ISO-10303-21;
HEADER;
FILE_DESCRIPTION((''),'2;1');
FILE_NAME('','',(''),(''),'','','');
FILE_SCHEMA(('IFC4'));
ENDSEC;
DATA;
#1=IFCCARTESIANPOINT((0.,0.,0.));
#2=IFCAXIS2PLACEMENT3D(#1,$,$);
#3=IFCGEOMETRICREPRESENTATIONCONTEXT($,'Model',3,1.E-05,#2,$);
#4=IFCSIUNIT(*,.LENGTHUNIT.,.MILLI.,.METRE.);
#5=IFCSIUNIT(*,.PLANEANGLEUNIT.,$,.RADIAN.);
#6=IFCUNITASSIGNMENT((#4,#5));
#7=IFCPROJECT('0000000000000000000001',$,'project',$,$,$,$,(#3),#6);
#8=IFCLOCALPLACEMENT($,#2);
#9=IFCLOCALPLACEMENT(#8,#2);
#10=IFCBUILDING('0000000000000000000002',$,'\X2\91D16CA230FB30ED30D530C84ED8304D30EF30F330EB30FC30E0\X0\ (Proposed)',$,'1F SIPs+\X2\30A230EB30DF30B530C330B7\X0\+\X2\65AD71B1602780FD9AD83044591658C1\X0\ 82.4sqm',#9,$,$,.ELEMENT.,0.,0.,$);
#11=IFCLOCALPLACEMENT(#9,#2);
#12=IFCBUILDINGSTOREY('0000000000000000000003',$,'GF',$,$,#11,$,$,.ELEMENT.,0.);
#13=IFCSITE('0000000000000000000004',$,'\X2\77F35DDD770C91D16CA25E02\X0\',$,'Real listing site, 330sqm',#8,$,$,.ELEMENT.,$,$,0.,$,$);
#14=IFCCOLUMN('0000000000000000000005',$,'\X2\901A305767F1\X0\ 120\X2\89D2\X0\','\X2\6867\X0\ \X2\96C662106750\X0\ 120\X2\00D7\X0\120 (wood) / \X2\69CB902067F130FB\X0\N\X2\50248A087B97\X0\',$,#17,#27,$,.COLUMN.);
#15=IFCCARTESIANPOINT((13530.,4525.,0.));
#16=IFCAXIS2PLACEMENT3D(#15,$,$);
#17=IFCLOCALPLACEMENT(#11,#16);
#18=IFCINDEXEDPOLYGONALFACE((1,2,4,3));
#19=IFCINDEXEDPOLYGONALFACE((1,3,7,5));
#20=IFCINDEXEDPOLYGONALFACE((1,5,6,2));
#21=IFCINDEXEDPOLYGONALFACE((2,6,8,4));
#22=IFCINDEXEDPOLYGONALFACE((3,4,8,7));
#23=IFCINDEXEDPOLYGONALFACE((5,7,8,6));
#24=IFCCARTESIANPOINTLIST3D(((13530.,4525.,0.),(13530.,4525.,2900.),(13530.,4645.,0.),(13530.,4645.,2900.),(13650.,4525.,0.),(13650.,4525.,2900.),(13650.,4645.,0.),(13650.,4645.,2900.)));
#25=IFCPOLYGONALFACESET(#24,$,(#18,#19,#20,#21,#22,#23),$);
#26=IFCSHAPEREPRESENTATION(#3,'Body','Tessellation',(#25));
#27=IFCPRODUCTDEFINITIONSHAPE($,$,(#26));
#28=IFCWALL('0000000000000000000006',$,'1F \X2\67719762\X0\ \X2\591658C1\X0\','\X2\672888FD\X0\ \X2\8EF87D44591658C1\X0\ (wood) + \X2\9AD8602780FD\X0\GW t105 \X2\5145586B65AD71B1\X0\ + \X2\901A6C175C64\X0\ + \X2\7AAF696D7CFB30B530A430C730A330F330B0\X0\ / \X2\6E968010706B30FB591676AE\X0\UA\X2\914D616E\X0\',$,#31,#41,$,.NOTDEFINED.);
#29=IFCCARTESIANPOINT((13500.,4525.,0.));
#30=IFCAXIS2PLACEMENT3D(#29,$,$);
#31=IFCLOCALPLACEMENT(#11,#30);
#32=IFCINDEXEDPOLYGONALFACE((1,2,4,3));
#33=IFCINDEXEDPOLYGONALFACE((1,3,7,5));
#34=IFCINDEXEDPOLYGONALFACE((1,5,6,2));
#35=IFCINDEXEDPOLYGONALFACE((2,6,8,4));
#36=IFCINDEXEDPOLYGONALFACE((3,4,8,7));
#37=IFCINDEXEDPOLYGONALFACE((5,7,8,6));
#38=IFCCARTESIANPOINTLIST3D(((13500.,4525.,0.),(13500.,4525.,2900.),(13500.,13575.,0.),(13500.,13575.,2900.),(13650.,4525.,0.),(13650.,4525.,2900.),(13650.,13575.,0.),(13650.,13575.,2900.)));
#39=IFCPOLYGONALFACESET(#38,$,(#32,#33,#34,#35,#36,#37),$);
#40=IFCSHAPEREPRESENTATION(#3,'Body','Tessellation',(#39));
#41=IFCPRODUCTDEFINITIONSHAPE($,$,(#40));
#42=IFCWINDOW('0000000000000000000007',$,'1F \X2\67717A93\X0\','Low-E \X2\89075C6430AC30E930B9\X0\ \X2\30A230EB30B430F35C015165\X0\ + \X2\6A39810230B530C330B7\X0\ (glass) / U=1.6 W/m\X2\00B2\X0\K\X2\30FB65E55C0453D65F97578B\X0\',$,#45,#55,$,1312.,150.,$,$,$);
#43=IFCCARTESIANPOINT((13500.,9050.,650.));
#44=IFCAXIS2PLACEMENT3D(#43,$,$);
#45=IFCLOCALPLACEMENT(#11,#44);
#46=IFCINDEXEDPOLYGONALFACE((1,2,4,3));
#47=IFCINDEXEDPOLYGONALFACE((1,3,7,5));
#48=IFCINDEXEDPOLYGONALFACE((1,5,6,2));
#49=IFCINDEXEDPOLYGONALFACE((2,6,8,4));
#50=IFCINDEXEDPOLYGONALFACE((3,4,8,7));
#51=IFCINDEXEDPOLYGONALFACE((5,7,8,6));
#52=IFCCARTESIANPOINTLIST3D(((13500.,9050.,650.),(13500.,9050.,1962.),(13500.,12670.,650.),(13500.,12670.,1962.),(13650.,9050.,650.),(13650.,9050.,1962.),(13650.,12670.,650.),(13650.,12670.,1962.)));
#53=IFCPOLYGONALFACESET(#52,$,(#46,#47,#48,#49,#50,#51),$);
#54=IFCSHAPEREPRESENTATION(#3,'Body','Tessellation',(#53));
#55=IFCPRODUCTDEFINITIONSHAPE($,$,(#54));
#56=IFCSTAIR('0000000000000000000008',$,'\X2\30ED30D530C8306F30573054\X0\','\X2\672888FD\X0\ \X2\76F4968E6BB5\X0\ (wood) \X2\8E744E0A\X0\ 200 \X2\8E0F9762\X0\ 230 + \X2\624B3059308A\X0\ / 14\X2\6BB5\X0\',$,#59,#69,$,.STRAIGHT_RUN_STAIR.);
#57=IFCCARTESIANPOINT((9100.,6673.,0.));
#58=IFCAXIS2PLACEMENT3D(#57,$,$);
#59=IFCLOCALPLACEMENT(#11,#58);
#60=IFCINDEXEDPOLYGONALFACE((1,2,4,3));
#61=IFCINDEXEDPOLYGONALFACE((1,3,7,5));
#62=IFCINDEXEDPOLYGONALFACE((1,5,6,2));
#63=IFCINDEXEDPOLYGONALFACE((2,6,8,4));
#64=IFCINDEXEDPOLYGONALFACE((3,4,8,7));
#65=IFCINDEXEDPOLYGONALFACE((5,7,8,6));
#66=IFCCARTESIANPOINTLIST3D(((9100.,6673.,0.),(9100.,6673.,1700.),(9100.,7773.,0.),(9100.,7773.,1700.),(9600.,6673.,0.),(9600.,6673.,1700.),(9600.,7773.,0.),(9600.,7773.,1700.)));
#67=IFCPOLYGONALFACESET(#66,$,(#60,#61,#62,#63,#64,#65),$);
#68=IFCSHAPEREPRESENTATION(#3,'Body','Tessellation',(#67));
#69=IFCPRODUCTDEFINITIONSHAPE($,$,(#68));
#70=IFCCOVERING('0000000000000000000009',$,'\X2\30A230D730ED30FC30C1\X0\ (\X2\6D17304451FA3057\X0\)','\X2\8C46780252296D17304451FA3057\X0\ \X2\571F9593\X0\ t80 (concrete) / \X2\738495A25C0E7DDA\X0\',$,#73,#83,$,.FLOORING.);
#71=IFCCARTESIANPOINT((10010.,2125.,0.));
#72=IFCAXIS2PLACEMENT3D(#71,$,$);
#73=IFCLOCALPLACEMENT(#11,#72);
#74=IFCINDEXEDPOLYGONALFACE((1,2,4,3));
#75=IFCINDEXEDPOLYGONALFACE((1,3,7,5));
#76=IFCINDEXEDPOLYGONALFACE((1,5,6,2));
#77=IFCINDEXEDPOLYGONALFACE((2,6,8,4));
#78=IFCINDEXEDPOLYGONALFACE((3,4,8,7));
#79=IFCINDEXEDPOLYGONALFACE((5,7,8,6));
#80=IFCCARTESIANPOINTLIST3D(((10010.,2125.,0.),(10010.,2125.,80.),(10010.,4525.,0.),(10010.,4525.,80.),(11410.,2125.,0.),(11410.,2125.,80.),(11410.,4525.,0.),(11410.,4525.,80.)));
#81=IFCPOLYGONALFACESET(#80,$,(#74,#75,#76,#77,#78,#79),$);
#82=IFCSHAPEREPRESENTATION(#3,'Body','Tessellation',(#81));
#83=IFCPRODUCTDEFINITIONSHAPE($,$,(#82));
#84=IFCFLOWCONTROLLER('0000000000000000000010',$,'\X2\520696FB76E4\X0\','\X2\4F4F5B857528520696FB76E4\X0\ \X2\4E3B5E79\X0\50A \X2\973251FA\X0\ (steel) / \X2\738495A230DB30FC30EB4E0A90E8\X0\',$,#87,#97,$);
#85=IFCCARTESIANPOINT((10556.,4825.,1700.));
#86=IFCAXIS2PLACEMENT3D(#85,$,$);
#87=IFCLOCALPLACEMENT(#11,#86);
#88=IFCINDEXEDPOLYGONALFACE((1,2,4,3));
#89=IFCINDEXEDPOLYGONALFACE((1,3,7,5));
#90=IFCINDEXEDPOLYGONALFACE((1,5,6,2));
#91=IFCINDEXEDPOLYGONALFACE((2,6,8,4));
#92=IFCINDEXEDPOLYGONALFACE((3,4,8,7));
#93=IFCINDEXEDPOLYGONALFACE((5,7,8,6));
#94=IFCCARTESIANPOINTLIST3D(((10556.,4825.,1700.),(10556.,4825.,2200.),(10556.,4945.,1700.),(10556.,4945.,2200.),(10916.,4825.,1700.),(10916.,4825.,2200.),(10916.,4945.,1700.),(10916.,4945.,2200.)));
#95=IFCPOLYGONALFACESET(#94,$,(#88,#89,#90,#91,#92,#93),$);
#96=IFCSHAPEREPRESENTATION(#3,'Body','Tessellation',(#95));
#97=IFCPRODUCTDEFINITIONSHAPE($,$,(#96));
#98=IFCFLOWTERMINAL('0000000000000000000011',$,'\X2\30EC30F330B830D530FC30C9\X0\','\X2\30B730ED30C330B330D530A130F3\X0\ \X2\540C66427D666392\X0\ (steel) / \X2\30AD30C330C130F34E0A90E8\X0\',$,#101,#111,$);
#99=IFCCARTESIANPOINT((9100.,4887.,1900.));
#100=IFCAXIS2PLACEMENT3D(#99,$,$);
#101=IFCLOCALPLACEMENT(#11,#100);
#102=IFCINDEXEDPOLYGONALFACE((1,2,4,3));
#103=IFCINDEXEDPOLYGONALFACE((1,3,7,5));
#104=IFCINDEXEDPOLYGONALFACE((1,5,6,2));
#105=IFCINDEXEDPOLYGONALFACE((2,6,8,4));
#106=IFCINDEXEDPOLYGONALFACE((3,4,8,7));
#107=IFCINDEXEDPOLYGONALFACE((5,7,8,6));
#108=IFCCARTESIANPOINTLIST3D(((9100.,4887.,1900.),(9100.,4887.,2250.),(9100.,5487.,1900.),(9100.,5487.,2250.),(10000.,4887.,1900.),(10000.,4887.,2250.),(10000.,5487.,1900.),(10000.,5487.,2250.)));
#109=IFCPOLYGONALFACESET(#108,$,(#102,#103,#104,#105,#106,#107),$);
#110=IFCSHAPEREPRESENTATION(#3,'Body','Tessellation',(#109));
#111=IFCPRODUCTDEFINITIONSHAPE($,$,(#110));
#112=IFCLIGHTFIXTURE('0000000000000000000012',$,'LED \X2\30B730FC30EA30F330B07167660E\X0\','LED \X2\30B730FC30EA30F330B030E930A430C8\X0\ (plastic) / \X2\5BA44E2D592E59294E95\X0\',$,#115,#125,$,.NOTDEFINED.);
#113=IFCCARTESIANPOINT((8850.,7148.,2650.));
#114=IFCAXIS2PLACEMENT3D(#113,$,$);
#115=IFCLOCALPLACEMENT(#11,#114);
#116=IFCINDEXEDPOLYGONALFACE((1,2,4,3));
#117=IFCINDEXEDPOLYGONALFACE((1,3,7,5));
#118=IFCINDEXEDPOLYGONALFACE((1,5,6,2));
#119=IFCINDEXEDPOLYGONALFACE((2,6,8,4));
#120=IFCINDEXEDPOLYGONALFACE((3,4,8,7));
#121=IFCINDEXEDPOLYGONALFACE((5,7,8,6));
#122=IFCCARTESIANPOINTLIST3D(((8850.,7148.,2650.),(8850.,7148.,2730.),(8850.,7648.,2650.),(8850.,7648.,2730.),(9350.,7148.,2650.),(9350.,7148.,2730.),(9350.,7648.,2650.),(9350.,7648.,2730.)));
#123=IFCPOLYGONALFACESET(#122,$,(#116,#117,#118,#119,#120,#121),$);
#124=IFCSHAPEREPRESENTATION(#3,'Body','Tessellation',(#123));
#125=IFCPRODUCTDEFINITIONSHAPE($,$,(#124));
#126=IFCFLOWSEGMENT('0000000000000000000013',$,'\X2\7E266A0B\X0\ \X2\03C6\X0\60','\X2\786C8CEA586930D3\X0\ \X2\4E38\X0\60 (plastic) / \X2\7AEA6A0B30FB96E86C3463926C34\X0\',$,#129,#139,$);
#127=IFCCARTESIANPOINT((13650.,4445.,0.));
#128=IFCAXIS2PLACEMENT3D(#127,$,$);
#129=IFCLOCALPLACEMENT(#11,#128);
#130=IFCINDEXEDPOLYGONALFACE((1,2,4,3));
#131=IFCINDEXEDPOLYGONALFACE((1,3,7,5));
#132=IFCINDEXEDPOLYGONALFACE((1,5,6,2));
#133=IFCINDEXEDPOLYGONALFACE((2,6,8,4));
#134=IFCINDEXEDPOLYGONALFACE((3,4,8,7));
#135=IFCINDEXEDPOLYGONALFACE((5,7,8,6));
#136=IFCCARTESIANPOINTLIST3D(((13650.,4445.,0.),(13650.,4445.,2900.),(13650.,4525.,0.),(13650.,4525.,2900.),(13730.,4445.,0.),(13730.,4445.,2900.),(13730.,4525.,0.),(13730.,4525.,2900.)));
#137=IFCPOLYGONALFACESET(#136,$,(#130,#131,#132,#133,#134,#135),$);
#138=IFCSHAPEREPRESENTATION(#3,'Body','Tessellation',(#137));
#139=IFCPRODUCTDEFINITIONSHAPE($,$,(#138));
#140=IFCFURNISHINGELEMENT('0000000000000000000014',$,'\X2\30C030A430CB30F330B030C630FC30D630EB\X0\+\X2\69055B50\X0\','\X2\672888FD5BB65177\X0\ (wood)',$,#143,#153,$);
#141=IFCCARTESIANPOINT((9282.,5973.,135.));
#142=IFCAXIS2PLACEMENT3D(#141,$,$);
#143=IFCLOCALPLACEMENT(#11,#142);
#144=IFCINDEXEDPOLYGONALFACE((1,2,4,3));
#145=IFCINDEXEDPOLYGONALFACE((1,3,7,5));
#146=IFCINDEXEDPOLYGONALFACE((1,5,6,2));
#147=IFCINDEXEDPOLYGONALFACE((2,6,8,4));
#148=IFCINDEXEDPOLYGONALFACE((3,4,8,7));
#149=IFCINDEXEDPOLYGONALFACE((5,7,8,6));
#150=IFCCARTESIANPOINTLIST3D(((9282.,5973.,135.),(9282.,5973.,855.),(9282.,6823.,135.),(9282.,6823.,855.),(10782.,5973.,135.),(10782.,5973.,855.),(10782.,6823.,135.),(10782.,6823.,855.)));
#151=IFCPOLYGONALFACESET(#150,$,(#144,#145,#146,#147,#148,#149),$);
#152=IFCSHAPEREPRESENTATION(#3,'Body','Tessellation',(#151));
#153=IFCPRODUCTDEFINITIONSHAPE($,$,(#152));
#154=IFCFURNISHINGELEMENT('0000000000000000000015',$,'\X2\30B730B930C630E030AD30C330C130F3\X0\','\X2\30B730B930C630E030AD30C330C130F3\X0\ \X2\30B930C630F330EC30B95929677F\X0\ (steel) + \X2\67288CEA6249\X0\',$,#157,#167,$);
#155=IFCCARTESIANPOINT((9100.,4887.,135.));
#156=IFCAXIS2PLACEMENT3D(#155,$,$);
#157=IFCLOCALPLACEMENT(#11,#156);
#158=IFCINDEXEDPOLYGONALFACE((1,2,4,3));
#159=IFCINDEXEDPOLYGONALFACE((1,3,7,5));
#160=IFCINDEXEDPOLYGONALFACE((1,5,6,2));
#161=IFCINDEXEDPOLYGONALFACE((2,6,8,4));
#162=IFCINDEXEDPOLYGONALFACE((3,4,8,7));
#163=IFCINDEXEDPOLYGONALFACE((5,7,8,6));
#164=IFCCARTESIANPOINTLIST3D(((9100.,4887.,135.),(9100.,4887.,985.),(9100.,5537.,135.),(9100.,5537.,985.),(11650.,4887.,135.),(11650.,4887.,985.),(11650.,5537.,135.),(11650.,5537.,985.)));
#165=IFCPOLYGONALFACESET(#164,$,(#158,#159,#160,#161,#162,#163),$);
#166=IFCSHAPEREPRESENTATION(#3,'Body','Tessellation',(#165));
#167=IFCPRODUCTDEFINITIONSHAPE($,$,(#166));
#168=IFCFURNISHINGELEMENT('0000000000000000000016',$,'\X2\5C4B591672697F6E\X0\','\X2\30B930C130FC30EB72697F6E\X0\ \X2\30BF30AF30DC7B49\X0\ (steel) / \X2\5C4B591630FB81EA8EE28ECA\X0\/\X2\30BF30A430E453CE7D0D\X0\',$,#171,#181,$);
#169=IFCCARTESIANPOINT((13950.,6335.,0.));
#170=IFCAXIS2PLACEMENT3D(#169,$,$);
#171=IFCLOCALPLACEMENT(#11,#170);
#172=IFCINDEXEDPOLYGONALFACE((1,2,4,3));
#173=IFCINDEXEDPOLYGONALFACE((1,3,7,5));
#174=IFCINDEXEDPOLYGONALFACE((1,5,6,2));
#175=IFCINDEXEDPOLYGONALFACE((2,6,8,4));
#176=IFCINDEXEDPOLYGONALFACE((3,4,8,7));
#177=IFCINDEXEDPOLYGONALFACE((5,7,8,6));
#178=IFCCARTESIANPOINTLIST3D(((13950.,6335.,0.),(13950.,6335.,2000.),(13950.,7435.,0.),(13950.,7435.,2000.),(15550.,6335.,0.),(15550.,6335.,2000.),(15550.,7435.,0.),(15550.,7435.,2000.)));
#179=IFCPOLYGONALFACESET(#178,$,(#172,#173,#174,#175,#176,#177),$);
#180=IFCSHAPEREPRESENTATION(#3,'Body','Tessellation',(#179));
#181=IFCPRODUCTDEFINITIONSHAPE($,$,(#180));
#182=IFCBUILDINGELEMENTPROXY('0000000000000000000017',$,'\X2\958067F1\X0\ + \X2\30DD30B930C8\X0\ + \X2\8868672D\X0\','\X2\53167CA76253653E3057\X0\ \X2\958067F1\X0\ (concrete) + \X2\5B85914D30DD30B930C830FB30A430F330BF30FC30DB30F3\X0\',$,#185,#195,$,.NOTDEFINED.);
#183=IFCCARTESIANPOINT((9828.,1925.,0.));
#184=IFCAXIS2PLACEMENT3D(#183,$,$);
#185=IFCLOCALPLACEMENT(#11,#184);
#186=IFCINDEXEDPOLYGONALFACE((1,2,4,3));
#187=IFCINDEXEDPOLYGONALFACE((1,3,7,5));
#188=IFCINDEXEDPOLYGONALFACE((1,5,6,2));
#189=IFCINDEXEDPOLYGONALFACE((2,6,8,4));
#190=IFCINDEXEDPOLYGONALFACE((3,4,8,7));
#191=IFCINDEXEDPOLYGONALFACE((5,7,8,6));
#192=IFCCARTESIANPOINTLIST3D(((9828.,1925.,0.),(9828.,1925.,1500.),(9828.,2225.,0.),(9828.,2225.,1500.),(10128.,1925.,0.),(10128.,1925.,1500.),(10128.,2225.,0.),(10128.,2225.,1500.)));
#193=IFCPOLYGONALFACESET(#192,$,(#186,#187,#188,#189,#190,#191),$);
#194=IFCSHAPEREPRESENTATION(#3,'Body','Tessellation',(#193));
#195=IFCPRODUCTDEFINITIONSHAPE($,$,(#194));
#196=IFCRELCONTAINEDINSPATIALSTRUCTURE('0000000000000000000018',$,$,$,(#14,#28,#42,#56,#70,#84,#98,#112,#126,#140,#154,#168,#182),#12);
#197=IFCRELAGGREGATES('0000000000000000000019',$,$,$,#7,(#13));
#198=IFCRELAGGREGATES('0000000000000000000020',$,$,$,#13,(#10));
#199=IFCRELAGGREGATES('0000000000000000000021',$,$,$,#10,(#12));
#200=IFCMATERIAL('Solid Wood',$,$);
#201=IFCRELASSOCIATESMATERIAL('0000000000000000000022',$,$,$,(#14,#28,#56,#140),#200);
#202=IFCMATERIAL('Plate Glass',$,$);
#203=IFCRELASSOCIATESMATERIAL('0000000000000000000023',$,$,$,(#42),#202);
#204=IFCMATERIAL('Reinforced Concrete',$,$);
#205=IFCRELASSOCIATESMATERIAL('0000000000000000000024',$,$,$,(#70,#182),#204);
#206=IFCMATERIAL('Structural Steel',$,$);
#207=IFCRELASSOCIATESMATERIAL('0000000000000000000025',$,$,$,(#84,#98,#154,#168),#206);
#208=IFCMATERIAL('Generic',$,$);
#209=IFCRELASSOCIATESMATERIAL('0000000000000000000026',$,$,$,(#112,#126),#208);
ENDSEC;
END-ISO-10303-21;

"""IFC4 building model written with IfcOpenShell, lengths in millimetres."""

from ifc_helpers import new_model, si_unit, frame, frame_2d, origin, place, context, project, spatial, rectangle, extrude, material, element, fill, save


model = new_model("IFC4")

# Units and contexts
model_context = context("Model", 3, precision=1e-05, world=origin())
ifc_project = project(units=[si_unit("LENGTHUNIT", "METRE", prefix="MILLI"), si_unit("PLANEANGLEUNIT", "RADIAN")], contexts=[model_context])

# Site, building, storey
site_placement = place(None, origin())
site = spatial("IfcSite", under=ifc_project, at=site_placement, Name="石川県金沢市", ObjectType="Real listing site, 330sqm", CompositionType="ELEMENT", RefElevation=0.0)
building_placement = place(site_placement, origin())
building = spatial("IfcBuilding", under=site, at=building_placement, Name="金沢・ロフト付きワンルーム (Proposed)", ObjectType="1F SIPs+アルミサッシ+断熱性能高い外壁 82.4sqm", CompositionType="ELEMENT", ElevationOfRefHeight=0.0, ElevationOfTerrain=0.0)
storey_placement = place(building_placement, origin())
storey = spatial("IfcBuildingStorey", under=building, at=storey_placement, Name="GF", CompositionType="ELEMENT", Elevation=0.0)

# Column
ifc_material_1 = material(Name="Solid Wood")
column_1_placement = place(storey_placement, frame((13530.0, 4525.0, 0.0)))
element("IfcColumn", 1, at=column_1_placement, inside=storey, material=ifc_material_1, Name="通し柱 120角", Description="桧 集成材 120×120 (wood) / 構造柱・N値計算", PredefinedType="COLUMN", context=model_context, shape_type="SweptSolid", body=[
    extrude(rectangle(XDim=120.0, YDim=120.0, at=frame_2d((60.0, 60.0))), frame((13530.0, 4525.0, 0.0)), (0.0, 0.0, 1.0), 2900.0),
])

# Wall, opening, window
wall_1_placement = place(storey_placement, frame((13500.0, 4525.0, 0.0)))
wall_1 = element("IfcWall", 2, at=wall_1_placement, inside=storey, material=ifc_material_1, Name="1F 東面 外壁", Description="木製 軸組外壁 (wood) + 高性能GW t105 充填断熱 + 通気層 + 窯業系サイディング / 準耐火・外皮UA配慮", PredefinedType="NOTDEFINED", context=model_context, shape_type="SweptSolid", body=[
    extrude(rectangle(XDim=150.0, YDim=9050.0, at=frame_2d((75.0, 4525.0))), frame((13500.0, 4525.0, 0.0)), (0.0, 0.0, 1.0), 2900.0),
])
opening_placement = place(storey_placement, frame((13500.0, 9050.0, 650.0)))
opening = element("IfcOpeningElement", 3, at=opening_placement, cuts=wall_1, PredefinedType="NOTDEFINED", context=model_context, shape_type="SweptSolid", body=[
    extrude(rectangle(XDim=150.0, YDim=3620.0, at=frame_2d((75.0, 1810.0))), frame((13500.0, 9050.0, 650.0)), (0.0, 0.0, 1.0), 1312.0),
])
ifc_material_2 = material(Name="Plate Glass")
window_placement = place(storey_placement, frame((13500.0, 9050.0, 650.0)))
window = element("IfcWindow", 4, at=window_placement, inside=storey, material=ifc_material_2, Name="1F 東窓", Description="Low-E 複層ガラス アルゴン封入 + 樹脂サッシ (glass) / U=1.6 W/m²K・日射取得型", OverallHeight=1312.0, OverallWidth=150.0, context=model_context, shape_type="SweptSolid", body=[
    extrude(rectangle(XDim=150.0, YDim=3620.0, at=frame_2d((75.0, 1810.0))), frame((13500.0, 9050.0, 650.0)), (0.0, 0.0, 1.0), 1312.0),
])
fill(opening, window)

# Stair
stair_placement = place(storey_placement, frame((9100.0, 6673.0, 0.0)))
element("IfcStair", 5, at=stair_placement, inside=storey, material=ifc_material_1, Name="ロフトはしご", Description="木製 直階段 (wood) 蹴上 200 踏面 230 + 手すり / 14段", PredefinedType="STRAIGHT_RUN_STAIR", context=model_context, shape_type="SweptSolid", body=[
    extrude(rectangle(XDim=500.0, YDim=1100.0, at=frame_2d((250.0, 550.0))), frame((9100.0, 6673.0, 0.0)), (0.0, 0.0, 1.0), 1700.0),
])

# Covering
ifc_material_3 = material(Name="Reinforced Concrete")
covering_placement = place(storey_placement, frame((10010.0, 2125.0, 0.0)))
element("IfcCovering", 6, at=covering_placement, inside=storey, material=ifc_material_3, Name="アプローチ (洗い出し)", Description="豆砂利洗い出し 土間 t80 (concrete) / 玄関導線", PredefinedType="FLOORING", context=model_context, shape_type="SweptSolid", body=[
    extrude(rectangle(XDim=1400.0, YDim=2400.0, at=frame_2d((700.0, 1200.0))), frame((10010.0, 2125.0, 0.0)), (0.0, 0.0, 1.0), 80.0),
])

# Flow controller
ifc_material_4 = material(Name="Structural Steel")
flow_controller_placement = place(storey_placement, frame((10556.0, 4825.0, 1700.0)))
element("IfcFlowController", 7, at=flow_controller_placement, inside=storey, material=ifc_material_4, Name="分電盤", Description="住宅用分電盤 主幹50A 露出 (steel) / 玄関ホール上部", context=model_context, shape_type="SweptSolid", body=[
    extrude(rectangle(XDim=360.0, YDim=120.0, at=frame_2d((180.0, 60.0))), frame((10556.0, 4825.0, 1700.0)), (0.0, 0.0, 1.0), 500.0),
])

# Flow terminal
flow_terminal_placement = place(storey_placement, frame((9100.0, 4887.0, 1900.0)))
element("IfcFlowTerminal", 8, at=flow_terminal_placement, inside=storey, material=ifc_material_4, Name="レンジフード", Description="シロッコファン 同時給排 (steel) / キッチン上部", context=model_context, shape_type="SweptSolid", body=[
    extrude(rectangle(XDim=900.0, YDim=600.0, at=frame_2d((450.0, 300.0))), frame((9100.0, 4887.0, 1900.0)), (0.0, 0.0, 1.0), 350.0),
])

# Light fixture
ifc_material_5 = material(Name="Generic")
light_fixture_placement = place(storey_placement, frame((8850.0, 7148.0, 2650.0)))
element("IfcLightFixture", 9, at=light_fixture_placement, inside=storey, material=ifc_material_5, Name="LED シーリング照明", Description="LED シーリングライト (plastic) / 室中央天井", PredefinedType="NOTDEFINED", context=model_context, shape_type="SweptSolid", body=[
    extrude(rectangle(XDim=500.0, YDim=500.0, at=frame_2d((250.0, 250.0))), frame((8850.0, 7148.0, 2650.0)), (0.0, 0.0, 1.0), 80.0),
])

# Flow segment
flow_segment_placement = place(storey_placement, frame((13650.0, 4445.0, 0.0)))
element("IfcFlowSegment", 10, at=flow_segment_placement, inside=storey, material=ifc_material_5, Name="縦樋 φ60", Description="硬質塩ビ 丸60 (plastic) / 竪樋・雨水排水", context=model_context, shape_type="SweptSolid", body=[
    extrude(rectangle(XDim=80.0, YDim=80.0, at=frame_2d((40.0, 40.0))), frame((13650.0, 4445.0, 0.0)), (0.0, 0.0, 1.0), 2900.0),
])

# Furnishing elements
furnishing_1_placement = place(storey_placement, frame((9282.0, 5973.0, 135.0)))
element("IfcFurnishingElement", 11, at=furnishing_1_placement, inside=storey, material=ifc_material_1, Name="ダイニングテーブル+椅子", Description="木製家具 (wood)", context=model_context, shape_type="SweptSolid", body=[
    extrude(rectangle(XDim=1500.0, YDim=850.0, at=frame_2d((750.0, 425.0))), frame((9282.0, 5973.0, 135.0)), (0.0, 0.0, 1.0), 720.0),
])
furnishing_2_placement = place(storey_placement, frame((9100.0, 4887.0, 135.0)))
element("IfcFurnishingElement", 12, at=furnishing_2_placement, inside=storey, material=ifc_material_4, Name="システムキッチン", Description="システムキッチン ステンレス天板 (steel) + 木質扉", context=model_context, shape_type="SweptSolid", body=[
    extrude(rectangle(XDim=2550.0, YDim=650.0, at=frame_2d((1275.0, 325.0))), frame((9100.0, 4887.0, 135.0)), (0.0, 0.0, 1.0), 850.0),
])
furnishing_3_placement = place(storey_placement, frame((13950.0, 6335.0, 0.0)))
element("IfcFurnishingElement", 13, at=furnishing_3_placement, inside=storey, material=ifc_material_4, Name="屋外物置", Description="スチール物置 タクボ等 (steel) / 屋外・自転車/タイヤ収納", context=model_context, shape_type="SweptSolid", body=[
    extrude(rectangle(XDim=1600.0, YDim=1100.0, at=frame_2d((800.0, 550.0))), frame((13950.0, 6335.0, 0.0)), (0.0, 0.0, 1.0), 2000.0),
])

# Building element proxy
proxy_placement = place(storey_placement, frame((9828.0, 1925.0, 0.0)))
element("IfcBuildingElementProxy", 14, at=proxy_placement, inside=storey, material=ifc_material_3, Name="門柱 + ポスト + 表札", Description="化粧打放し 門柱 (concrete) + 宅配ポスト・インターホン", PredefinedType="NOTDEFINED", context=model_context, shape_type="SweptSolid", body=[
    extrude(rectangle(XDim=300.0, YDim=300.0, at=frame_2d((150.0, 150.0))), frame((9828.0, 1925.0, 0.0)), (0.0, 0.0, 1.0), 1500.0),
])

save(model, "model.ifc")
